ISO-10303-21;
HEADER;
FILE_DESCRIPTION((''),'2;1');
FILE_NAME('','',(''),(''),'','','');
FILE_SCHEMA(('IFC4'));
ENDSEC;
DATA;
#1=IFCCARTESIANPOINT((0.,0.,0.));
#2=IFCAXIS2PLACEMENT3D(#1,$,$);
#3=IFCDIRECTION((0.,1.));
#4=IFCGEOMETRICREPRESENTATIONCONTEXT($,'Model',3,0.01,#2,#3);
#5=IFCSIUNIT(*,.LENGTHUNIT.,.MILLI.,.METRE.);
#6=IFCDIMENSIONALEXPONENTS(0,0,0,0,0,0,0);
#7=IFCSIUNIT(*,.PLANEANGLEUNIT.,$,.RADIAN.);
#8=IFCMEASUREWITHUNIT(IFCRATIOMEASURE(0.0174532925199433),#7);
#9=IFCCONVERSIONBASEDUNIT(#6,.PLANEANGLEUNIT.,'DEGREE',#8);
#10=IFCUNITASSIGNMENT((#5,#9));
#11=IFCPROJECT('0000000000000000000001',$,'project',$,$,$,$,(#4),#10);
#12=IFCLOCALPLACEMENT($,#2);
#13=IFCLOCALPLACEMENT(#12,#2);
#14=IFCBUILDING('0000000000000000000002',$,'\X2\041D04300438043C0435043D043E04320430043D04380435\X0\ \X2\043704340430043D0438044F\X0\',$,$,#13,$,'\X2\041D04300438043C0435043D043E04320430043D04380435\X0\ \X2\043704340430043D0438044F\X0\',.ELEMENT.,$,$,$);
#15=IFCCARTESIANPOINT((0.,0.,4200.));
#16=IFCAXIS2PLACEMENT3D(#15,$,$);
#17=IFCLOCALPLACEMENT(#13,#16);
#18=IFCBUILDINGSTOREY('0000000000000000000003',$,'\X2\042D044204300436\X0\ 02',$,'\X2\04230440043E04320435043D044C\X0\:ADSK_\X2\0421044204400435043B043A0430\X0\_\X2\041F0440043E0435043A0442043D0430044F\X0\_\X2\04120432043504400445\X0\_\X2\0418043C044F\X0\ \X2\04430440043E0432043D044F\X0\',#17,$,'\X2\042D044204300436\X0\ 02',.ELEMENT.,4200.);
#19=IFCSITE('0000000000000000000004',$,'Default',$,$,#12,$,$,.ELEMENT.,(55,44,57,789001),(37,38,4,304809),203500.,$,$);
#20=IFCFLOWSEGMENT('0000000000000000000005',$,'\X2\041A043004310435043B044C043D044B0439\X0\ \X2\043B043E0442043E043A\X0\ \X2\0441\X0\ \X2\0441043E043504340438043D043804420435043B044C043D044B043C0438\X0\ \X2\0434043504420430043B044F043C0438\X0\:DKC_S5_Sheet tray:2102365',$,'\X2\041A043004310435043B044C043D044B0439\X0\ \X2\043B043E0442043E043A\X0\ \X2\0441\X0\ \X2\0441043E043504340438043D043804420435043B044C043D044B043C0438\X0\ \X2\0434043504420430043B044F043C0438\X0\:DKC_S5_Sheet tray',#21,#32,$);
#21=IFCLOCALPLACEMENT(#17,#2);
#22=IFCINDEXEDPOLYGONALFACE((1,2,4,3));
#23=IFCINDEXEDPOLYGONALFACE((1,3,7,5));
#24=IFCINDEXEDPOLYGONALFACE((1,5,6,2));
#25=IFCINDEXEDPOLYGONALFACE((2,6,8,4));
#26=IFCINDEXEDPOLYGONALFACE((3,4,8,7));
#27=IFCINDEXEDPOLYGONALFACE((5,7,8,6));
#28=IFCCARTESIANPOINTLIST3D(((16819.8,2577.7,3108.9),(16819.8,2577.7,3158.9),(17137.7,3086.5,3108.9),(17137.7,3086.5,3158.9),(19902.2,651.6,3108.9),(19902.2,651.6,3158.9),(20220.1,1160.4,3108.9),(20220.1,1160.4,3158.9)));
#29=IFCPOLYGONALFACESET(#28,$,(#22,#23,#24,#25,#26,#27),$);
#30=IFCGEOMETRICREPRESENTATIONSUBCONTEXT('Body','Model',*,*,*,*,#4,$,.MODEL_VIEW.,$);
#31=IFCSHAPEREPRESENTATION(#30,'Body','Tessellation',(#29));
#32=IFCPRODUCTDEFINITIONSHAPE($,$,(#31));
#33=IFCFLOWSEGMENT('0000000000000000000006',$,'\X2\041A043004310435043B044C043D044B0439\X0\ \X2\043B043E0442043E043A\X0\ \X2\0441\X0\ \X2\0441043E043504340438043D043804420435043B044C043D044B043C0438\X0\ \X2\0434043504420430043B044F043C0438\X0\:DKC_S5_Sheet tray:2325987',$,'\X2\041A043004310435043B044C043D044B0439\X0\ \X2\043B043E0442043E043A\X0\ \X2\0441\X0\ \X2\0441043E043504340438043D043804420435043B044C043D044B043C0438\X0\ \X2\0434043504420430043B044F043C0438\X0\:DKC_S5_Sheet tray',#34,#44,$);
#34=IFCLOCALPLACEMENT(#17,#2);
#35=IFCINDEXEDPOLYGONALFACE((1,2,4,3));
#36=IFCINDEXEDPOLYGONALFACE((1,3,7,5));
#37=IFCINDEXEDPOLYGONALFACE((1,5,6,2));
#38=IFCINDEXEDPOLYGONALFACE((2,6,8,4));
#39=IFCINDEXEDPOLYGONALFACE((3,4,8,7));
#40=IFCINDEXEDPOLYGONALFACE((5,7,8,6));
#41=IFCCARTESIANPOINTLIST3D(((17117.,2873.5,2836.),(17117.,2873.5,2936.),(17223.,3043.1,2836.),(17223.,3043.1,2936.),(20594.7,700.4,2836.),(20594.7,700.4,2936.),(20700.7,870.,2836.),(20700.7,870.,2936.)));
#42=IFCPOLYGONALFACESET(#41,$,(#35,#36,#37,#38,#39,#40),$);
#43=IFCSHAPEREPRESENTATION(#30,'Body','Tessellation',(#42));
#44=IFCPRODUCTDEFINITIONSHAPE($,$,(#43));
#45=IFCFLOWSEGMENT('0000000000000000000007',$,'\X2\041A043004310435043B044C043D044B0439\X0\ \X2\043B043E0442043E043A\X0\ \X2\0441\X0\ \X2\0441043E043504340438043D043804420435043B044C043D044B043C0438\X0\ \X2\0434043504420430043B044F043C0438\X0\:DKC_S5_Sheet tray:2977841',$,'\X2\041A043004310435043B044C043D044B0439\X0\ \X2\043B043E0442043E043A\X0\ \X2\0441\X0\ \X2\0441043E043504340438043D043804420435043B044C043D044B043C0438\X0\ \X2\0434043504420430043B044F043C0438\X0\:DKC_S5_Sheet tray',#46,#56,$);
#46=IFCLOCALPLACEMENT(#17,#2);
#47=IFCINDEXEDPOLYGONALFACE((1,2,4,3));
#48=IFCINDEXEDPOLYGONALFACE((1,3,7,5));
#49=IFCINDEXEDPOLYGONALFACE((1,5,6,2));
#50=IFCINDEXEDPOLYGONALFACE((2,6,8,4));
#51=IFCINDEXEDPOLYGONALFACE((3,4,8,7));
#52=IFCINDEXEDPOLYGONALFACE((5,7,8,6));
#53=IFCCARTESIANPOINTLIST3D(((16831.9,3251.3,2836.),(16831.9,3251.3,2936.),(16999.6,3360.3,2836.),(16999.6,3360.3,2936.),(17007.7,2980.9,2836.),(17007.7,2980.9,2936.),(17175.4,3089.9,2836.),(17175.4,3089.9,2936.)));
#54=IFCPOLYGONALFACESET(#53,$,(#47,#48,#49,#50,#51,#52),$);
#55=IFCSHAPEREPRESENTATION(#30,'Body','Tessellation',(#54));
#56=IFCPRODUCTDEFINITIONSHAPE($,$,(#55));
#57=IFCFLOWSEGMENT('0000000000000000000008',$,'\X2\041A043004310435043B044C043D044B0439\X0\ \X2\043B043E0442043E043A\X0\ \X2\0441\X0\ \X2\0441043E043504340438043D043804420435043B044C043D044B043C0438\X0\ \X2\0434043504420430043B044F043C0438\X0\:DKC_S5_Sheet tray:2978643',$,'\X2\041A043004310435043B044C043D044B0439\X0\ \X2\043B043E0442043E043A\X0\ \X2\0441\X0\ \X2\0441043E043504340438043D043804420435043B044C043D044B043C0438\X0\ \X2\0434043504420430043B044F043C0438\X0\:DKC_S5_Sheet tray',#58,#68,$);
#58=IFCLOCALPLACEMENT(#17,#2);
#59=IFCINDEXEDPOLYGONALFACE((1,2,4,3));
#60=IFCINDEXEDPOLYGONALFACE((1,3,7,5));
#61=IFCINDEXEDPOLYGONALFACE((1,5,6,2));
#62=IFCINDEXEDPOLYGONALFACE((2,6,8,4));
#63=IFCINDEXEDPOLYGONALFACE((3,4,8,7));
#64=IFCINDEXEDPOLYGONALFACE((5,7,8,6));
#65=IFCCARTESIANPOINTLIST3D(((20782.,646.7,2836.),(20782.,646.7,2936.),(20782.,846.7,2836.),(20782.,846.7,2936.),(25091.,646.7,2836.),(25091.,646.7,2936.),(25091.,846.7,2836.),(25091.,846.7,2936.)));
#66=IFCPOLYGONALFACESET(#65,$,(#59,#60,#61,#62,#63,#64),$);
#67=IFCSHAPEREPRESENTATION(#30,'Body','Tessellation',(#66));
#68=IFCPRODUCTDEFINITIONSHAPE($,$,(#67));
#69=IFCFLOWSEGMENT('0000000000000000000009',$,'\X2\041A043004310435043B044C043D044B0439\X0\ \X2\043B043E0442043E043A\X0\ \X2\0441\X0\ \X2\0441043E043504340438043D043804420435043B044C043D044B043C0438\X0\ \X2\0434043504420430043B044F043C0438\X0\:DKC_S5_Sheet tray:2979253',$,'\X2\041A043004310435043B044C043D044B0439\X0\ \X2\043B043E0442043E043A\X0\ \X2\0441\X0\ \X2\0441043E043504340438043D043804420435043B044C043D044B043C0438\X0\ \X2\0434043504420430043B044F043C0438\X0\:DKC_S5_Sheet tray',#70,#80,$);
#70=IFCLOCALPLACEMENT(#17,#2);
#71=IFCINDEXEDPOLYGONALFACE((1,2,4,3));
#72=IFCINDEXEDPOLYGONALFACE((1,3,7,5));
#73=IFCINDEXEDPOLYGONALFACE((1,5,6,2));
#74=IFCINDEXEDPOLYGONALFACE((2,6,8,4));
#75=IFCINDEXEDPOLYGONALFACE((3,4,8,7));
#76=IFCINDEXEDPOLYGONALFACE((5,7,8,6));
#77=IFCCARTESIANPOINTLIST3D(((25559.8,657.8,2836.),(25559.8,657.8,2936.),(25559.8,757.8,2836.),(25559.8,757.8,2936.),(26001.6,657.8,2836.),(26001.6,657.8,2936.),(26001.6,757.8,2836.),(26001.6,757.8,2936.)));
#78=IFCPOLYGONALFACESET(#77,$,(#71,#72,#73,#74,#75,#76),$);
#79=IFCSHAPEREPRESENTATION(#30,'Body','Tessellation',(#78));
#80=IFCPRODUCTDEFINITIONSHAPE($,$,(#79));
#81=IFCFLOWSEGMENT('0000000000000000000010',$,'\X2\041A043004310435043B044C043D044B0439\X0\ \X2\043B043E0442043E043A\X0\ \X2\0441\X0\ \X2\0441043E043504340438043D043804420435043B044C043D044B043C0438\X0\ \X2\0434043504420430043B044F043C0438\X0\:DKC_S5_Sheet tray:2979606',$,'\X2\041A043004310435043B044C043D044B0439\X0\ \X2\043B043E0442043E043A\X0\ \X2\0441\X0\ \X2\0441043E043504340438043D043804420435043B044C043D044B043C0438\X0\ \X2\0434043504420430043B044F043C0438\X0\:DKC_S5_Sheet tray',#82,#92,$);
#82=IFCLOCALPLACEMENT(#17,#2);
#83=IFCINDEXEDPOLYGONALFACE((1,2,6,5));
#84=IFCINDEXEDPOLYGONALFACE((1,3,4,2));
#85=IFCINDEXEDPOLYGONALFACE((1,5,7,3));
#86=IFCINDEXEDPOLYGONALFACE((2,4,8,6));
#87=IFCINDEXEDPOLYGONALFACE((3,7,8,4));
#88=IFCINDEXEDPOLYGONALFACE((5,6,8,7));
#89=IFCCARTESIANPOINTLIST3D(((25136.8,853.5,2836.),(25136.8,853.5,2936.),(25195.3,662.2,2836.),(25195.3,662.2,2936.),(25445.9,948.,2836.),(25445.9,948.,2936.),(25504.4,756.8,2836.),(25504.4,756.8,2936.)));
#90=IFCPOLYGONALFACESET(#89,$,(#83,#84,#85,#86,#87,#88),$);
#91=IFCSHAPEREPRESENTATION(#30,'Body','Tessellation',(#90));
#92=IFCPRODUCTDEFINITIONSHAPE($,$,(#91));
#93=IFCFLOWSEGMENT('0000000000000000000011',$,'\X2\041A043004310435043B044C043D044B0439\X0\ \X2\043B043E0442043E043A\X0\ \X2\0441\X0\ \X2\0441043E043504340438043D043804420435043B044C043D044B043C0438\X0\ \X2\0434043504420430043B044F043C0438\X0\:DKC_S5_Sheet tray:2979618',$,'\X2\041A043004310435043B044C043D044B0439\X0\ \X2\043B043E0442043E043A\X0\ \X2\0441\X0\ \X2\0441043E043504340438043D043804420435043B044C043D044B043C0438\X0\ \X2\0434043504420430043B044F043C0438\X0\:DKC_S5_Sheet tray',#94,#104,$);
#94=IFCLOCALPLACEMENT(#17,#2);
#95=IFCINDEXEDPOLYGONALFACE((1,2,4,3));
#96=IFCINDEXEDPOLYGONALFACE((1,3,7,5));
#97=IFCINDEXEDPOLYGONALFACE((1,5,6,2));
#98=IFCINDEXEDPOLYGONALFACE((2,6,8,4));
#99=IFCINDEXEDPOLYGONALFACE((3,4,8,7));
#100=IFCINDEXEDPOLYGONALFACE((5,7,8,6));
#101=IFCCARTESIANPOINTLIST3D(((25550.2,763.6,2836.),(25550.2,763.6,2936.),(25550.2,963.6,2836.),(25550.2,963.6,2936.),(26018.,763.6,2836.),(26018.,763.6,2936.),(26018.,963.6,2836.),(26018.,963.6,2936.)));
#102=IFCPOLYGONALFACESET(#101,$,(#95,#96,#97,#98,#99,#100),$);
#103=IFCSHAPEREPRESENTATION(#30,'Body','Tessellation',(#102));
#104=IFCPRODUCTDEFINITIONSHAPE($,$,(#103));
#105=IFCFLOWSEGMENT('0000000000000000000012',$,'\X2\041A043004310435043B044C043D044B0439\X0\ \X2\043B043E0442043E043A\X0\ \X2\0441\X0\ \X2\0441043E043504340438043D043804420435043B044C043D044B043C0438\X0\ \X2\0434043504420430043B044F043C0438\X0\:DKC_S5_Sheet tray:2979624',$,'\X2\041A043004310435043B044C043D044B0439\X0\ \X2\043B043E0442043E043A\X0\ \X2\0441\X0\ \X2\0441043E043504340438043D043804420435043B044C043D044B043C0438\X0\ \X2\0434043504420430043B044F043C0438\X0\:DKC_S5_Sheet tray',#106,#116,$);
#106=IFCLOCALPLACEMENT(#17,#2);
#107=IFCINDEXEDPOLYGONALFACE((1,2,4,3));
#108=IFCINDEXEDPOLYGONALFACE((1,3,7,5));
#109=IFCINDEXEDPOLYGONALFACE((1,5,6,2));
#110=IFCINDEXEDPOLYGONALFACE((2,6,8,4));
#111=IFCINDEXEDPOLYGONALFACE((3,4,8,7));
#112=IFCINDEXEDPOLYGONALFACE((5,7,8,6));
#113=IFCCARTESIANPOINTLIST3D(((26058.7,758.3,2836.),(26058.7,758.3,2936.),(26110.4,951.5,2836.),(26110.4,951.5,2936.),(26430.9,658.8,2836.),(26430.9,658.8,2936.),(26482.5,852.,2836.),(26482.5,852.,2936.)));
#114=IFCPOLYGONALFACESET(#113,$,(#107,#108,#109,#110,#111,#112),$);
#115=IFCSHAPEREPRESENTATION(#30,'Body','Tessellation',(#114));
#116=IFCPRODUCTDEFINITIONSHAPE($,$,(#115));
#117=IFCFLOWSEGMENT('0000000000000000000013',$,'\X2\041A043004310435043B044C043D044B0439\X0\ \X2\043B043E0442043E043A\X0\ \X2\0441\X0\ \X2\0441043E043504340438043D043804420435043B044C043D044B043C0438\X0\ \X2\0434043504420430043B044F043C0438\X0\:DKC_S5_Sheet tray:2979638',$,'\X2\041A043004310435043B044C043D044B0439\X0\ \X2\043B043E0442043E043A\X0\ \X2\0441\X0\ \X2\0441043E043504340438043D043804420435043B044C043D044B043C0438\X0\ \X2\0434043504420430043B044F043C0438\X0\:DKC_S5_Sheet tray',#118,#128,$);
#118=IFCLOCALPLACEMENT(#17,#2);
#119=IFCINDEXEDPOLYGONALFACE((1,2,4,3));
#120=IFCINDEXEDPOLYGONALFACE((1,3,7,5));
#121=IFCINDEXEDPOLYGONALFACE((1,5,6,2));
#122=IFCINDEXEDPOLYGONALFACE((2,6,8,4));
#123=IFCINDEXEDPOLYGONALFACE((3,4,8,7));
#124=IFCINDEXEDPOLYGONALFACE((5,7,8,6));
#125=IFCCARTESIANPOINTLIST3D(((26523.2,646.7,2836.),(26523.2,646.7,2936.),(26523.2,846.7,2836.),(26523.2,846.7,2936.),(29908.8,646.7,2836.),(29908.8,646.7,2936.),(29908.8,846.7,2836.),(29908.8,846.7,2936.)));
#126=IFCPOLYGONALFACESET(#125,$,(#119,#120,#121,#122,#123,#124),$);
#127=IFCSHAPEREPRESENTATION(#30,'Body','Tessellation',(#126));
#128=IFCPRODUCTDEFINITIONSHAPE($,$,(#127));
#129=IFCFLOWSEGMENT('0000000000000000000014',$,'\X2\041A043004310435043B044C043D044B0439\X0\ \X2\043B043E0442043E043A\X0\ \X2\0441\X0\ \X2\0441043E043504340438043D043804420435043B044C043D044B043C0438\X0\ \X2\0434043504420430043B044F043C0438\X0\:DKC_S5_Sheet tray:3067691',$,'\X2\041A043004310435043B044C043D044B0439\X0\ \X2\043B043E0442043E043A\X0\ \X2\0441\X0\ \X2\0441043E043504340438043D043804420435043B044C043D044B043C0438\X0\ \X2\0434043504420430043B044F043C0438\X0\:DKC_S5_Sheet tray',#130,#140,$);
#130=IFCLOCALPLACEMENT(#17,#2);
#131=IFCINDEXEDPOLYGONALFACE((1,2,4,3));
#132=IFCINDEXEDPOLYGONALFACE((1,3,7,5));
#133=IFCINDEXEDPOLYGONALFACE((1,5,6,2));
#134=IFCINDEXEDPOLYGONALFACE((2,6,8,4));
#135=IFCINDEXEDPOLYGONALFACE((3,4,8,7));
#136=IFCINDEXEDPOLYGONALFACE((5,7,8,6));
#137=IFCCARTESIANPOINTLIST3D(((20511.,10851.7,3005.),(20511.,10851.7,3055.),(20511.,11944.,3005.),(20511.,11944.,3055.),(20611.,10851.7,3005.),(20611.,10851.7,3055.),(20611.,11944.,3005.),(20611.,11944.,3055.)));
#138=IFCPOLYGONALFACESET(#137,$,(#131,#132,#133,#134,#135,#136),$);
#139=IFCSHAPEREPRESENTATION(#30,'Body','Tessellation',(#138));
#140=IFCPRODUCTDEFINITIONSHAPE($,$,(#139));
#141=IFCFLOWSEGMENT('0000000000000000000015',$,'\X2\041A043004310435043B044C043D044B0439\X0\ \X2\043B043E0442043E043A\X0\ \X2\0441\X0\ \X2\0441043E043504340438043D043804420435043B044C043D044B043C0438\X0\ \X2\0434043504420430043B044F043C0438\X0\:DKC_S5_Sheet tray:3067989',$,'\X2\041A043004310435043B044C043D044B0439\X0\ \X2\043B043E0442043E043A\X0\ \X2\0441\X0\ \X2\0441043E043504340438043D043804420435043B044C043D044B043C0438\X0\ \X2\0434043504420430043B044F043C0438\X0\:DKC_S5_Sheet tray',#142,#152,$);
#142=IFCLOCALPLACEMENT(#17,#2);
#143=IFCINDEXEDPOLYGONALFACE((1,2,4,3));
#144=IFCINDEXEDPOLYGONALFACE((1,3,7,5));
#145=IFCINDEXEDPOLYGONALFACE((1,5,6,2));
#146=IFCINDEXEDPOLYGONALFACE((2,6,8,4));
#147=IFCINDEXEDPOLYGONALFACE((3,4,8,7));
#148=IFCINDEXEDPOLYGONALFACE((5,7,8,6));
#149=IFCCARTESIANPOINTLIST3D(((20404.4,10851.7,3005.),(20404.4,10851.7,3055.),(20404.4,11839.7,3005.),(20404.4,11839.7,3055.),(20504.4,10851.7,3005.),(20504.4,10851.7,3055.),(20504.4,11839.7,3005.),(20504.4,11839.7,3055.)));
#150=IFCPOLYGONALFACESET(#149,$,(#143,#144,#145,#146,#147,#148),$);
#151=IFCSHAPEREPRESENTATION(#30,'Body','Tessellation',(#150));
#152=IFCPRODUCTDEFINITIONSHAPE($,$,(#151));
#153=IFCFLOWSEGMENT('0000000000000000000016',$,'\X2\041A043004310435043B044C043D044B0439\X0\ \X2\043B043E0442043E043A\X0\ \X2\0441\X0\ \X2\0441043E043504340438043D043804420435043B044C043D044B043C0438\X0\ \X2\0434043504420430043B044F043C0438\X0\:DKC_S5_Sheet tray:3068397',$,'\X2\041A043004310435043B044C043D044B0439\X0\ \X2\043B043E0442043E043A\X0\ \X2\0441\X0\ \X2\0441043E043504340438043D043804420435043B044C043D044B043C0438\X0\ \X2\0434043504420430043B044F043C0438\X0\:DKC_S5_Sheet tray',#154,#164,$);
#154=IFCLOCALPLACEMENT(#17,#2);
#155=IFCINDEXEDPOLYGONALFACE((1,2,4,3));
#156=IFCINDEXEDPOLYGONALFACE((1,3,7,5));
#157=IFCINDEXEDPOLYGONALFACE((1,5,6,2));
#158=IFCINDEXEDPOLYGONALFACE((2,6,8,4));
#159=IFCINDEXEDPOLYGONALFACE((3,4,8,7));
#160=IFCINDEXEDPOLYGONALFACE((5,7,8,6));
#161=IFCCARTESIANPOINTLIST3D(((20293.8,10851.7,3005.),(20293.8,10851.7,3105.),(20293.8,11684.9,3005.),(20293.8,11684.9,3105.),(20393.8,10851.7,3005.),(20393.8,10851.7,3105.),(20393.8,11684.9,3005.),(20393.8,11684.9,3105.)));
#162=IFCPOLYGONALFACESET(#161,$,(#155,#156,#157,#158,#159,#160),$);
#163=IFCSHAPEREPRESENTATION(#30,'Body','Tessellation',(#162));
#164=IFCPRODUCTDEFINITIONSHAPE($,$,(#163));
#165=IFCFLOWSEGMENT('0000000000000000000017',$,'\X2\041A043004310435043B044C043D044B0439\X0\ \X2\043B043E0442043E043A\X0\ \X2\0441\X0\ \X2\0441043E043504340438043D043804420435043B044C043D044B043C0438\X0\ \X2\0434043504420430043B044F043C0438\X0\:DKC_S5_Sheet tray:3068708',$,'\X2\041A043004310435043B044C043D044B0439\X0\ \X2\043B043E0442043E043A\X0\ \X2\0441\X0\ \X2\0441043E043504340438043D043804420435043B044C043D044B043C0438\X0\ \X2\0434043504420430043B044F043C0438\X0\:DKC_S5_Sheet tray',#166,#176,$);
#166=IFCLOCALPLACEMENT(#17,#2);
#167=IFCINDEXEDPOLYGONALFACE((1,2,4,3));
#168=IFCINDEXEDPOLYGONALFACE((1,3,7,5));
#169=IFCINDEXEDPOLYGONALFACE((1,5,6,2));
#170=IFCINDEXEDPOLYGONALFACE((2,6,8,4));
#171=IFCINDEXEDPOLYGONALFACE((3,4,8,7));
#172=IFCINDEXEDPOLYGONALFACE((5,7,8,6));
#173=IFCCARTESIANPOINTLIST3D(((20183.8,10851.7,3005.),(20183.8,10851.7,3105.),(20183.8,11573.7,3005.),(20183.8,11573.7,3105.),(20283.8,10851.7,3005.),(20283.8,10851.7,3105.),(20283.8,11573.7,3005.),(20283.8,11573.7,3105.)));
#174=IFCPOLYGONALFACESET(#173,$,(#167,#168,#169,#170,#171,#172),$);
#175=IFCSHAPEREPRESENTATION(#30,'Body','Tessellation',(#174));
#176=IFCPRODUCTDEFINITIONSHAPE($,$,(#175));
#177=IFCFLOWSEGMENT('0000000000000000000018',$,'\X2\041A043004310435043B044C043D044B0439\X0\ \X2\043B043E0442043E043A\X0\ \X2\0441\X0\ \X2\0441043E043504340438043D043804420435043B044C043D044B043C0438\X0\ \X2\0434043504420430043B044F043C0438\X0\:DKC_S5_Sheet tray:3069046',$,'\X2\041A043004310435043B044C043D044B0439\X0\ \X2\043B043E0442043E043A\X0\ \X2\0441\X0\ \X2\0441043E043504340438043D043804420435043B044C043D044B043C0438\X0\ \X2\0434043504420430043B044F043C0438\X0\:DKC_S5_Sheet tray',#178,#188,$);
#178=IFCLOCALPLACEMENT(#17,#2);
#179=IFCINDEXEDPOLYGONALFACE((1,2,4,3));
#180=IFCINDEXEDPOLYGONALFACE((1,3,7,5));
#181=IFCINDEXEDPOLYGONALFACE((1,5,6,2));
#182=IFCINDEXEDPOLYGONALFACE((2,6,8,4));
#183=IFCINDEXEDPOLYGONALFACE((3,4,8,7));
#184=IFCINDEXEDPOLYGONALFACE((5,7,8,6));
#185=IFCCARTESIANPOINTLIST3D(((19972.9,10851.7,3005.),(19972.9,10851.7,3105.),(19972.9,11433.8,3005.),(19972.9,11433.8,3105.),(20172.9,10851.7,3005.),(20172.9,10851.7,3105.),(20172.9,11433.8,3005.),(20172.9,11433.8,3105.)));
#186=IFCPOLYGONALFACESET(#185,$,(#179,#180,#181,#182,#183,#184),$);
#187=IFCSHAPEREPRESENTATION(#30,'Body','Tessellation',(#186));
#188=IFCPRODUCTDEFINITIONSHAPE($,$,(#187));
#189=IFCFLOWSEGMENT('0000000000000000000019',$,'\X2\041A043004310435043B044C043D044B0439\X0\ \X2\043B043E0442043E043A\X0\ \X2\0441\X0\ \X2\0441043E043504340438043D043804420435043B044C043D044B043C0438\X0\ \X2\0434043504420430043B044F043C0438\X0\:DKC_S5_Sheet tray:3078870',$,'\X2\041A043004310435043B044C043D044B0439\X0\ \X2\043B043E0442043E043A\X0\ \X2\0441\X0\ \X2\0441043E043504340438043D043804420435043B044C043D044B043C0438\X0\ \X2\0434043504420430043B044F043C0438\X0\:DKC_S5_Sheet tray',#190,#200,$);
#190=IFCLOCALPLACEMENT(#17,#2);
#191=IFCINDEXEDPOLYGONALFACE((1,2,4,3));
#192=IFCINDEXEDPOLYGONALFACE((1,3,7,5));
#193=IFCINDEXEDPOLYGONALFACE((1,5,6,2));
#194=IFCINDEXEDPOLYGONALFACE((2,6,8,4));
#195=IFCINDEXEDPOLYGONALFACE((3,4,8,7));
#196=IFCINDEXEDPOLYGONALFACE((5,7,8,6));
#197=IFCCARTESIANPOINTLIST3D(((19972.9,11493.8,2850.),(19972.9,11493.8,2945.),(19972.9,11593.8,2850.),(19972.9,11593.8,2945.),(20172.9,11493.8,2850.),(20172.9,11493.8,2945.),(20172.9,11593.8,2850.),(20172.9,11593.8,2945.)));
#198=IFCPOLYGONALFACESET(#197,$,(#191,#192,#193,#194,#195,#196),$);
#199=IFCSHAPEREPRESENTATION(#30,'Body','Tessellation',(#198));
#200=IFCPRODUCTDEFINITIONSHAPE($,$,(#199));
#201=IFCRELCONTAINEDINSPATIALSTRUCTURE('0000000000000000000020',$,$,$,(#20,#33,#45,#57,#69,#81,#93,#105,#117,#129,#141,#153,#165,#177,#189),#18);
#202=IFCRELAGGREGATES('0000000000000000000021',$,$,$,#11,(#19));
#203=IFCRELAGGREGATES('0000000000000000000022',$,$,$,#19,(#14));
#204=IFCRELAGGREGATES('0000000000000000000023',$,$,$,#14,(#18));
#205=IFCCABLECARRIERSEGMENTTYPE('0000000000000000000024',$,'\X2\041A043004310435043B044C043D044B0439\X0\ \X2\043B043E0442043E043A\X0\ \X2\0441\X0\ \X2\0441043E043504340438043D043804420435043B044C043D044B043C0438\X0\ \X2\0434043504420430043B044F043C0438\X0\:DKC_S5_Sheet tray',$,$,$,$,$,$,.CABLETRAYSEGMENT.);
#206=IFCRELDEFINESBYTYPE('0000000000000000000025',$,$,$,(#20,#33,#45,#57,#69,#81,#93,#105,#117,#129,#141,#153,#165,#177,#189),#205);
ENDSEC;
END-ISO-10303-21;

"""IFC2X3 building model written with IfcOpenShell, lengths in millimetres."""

from ifc_helpers import new_model, entity, si_unit, converted_unit, direction, frame, frame_2d, origin, origin_2d_with_axis, place, context, subcontext, project, spatial, rectangle, extrude, type_object, element, save


model = new_model("IFC2X3")

# Units and contexts
model_context = context("Model", 3, precision=0.01, world=origin(), true_north=direction((0.0, 1.0)))
body_context = subcontext(model_context, "Body", "Model", "MODEL_VIEW")
ifc_project = project(units=[si_unit("LENGTHUNIT", "METRE", prefix="MILLI"), converted_unit("PLANEANGLEUNIT", "DEGREE", entity("IfcRatioMeasure", 0.0174532925199433), si_unit("PLANEANGLEUNIT", "RADIAN"), dimensions=[0, 0, 0, 0, 0, 0, 0])], contexts=[model_context])

# Site, building, storey
site_placement = place(None, frame((0.0, 0.0, 0.0)))
site = spatial("IfcSite", under=ifc_project, at=site_placement, Name="Default", CompositionType="ELEMENT", RefLatitude=(55, 44, 57, 789001), RefLongitude=(37, 38, 4, 304809), RefElevation=203500.0)
building_placement = place(site_placement, origin())
building = spatial("IfcBuilding", under=site, at=building_placement, Name="Наименование здания", LongName="Наименование здания", CompositionType="ELEMENT")
storey_placement = place(building_placement, frame((0.0, 0.0, 4200.0)))
storey = spatial("IfcBuildingStorey", under=building, at=storey_placement, Name="Этаж 02", ObjectType="Уровень:ADSK_Стрелка_Проектная_Вверх_Имя уровня", LongName="Этаж 02", CompositionType="ELEMENT", Elevation=4200.0)

# Flow segments
cable_carrier_segment_type = type_object("IfcCableCarrierSegmentType", Name="Кабельный лоток с соединительными деталями:DKC_S5_Sheet tray", PredefinedType="CABLETRAYSEGMENT")
flow_segment_1_placement = place(storey_placement, frame((16819.8, 651.6, 3108.9)))
element("IfcFlowSegment", 1, at=flow_segment_1_placement, inside=storey, type_object=cable_carrier_segment_type, Name="Кабельный лоток с соединительными деталями:DKC_S5_Sheet tray:2102365", ObjectType="Кабельный лоток с соединительными деталями:DKC_S5_Sheet tray", context=body_context, shape_type="SweptSolid", body=[
    extrude(rectangle(XDim=3634.7, YDim=600.0, at=frame_2d((0.0, 0.0), x_axis=(1.0, 0.0))), frame((1700.2, 1217.5, 0.0), z_axis=(0.0, 0.0, 1.0), x_axis=(-0.848048, 0.529919, 0.0)), (0.0, 0.0, 1.0), 50.0),
])
flow_segment_2_placement = place(storey_placement, frame((17117.0, 700.4, 2836.0)))
element("IfcFlowSegment", 2, at=flow_segment_2_placement, inside=storey, type_object=cable_carrier_segment_type, Name="Кабельный лоток с соединительными деталями:DKC_S5_Sheet tray:2325987", ObjectType="Кабельный лоток с соединительными деталями:DKC_S5_Sheet tray", context=body_context, shape_type="SweptSolid", body=[
    extrude(rectangle(XDim=4100.8, YDim=200.0, at=frame_2d((0.0, 0.0), x_axis=(1.0, 0.0))), frame((1791.8, 1171.3, 0.0), z_axis=(0.0, 0.0, 1.0), x_axis=(-0.848048, 0.529919, 0.0)), (0.0, 0.0, 1.0), 100.0),
])
flow_segment_3_placement = place(storey_placement, frame((16831.9, 2980.9, 2836.0)))
element("IfcFlowSegment", 3, at=flow_segment_3_placement, inside=storey, type_object=cable_carrier_segment_type, Name="Кабельный лоток с соединительными деталями:DKC_S5_Sheet tray:2977841", ObjectType="Кабельный лоток с соединительными деталями:DKC_S5_Sheet tray", context=body_context, shape_type="SweptSolid", body=[
    extrude(rectangle(XDim=322.6, YDim=200.0, at=frame_2d((0.0, 0.0), x_axis=(1.0, 0.0))), frame((171.7, 189.7, 0.0), z_axis=(0.0, 0.0, 1.0), x_axis=(-0.54501, 0.838429, 0.0)), (0.0, 0.0, 1.0), 100.0),
])
flow_segment_4_placement = place(storey_placement, frame((20782.0, 646.7, 2836.0)))
element("IfcFlowSegment", 4, at=flow_segment_4_placement, inside=storey, type_object=cable_carrier_segment_type, Name="Кабельный лоток с соединительными деталями:DKC_S5_Sheet tray:2978643", ObjectType="Кабельный лоток с соединительными деталями:DKC_S5_Sheet tray", context=body_context, shape_type="SweptSolid", body=[
    extrude(rectangle(XDim=4309.0, YDim=200.0, at=frame_2d((0.0, 0.0), x_axis=(1.0, 0.0))), frame((2154.5, 100.0, 0.0)), (0.0, 0.0, 1.0), 100.0),
])
flow_segment_5_placement = place(storey_placement, frame((25559.8, 657.8, 2836.0)))
element("IfcFlowSegment", 5, at=flow_segment_5_placement, inside=storey, type_object=cable_carrier_segment_type, Name="Кабельный лоток с соединительными деталями:DKC_S5_Sheet tray:2979253", ObjectType="Кабельный лоток с соединительными деталями:DKC_S5_Sheet tray", context=body_context, shape_type="SweptSolid", body=[
    extrude(rectangle(XDim=441.8, YDim=100.0, at=frame_2d((0.0, 0.0), x_axis=(1.0, 0.0))), frame((220.9, 50.0, 0.0)), (0.0, 0.0, 1.0), 100.0),
])
flow_segment_6_placement = place(storey_placement, frame((25136.8, 662.2, 2836.0)))
element("IfcFlowSegment", 6, at=flow_segment_6_placement, inside=storey, type_object=cable_carrier_segment_type, Name="Кабельный лоток с соединительными деталями:DKC_S5_Sheet tray:2979606", ObjectType="Кабельный лоток с соединительными деталями:DKC_S5_Sheet tray", context=body_context, shape_type="SweptSolid", body=[
    extrude(rectangle(XDim=323.3, YDim=200.0, at=frame_2d((0.0, 0.0), x_axis=(1.0, 0.0))), frame((183.8, 142.9, 0.0), z_axis=(0.0, 0.0, 1.0), x_axis=(0.956305, 0.292372, 0.0)), (0.0, 0.0, 1.0), 100.0),
])
flow_segment_7_placement = place(storey_placement, frame((25550.2, 763.6, 2836.0)))
element("IfcFlowSegment", 7, at=flow_segment_7_placement, inside=storey, type_object=cable_carrier_segment_type, Name="Кабельный лоток с соединительными деталями:DKC_S5_Sheet tray:2979618", ObjectType="Кабельный лоток с соединительными деталями:DKC_S5_Sheet tray", context=body_context, shape_type="SweptSolid", body=[
    extrude(rectangle(XDim=467.8, YDim=200.0, at=frame_2d((0.0, 0.0), x_axis=(1.0, 0.0))), frame((233.9, 100.0, 0.0)), (0.0, 0.0, 1.0), 100.0),
])
flow_segment_8_placement = place(storey_placement, frame((26058.7, 658.8, 2836.0)))
element("IfcFlowSegment", 8, at=flow_segment_8_placement, inside=storey, type_object=cable_carrier_segment_type, Name="Кабельный лоток с соединительными деталями:DKC_S5_Sheet tray:2979624", ObjectType="Кабельный лоток с соединительными деталями:DKC_S5_Sheet tray", context=body_context, shape_type="SweptSolid", body=[
    extrude(rectangle(XDim=385.2, YDim=200.0, at=frame_2d((0.0, 0.0), x_axis=(1.0, 0.0))), frame((211.9, 146.3, 0.0), z_axis=(0.0, 0.0, 1.0), x_axis=(0.966084, -0.258228, 0.0)), (0.0, 0.0, 1.0), 100.0),
])
flow_segment_9_placement = place(storey_placement, frame((26523.2, 646.7, 2836.0)))
element("IfcFlowSegment", 9, at=flow_segment_9_placement, inside=storey, type_object=cable_carrier_segment_type, Name="Кабельный лоток с соединительными деталями:DKC_S5_Sheet tray:2979638", ObjectType="Кабельный лоток с соединительными деталями:DKC_S5_Sheet tray", context=body_context, shape_type="SweptSolid", body=[
    extrude(rectangle(XDim=3385.6, YDim=200.0, at=frame_2d((0.0, 0.0), x_axis=(1.0, 0.0))), frame((1692.8, 100.0, 0.0)), (0.0, 0.0, 1.0), 100.0),
])
flow_segment_10_placement = place(storey_placement, frame((20511.0, 10851.7, 3005.0)))
element("IfcFlowSegment", 10, at=flow_segment_10_placement, inside=storey, type_object=cable_carrier_segment_type, Name="Кабельный лоток с соединительными деталями:DKC_S5_Sheet tray:3067691", ObjectType="Кабельный лоток с соединительными деталями:DKC_S5_Sheet tray", context=body_context, shape_type="SweptSolid", body=[
    extrude(rectangle(XDim=1092.4, YDim=100.0, at=origin_2d_with_axis()), frame((50.0, 546.2, 0.0), z_axis=(0.0, 0.0, 1.0), x_axis=(0.0, -1.0, 0.0)), (0.0, 0.0, 1.0), 50.0),
])
flow_segment_11_placement = place(storey_placement, frame((20404.4, 10851.7, 3005.0)))
element("IfcFlowSegment", 11, at=flow_segment_11_placement, inside=storey, type_object=cable_carrier_segment_type, Name="Кабельный лоток с соединительными деталями:DKC_S5_Sheet tray:3067989", ObjectType="Кабельный лоток с соединительными деталями:DKC_S5_Sheet tray", context=body_context, shape_type="SweptSolid", body=[
    extrude(rectangle(XDim=988.0, YDim=100.0, at=frame_2d((0.0, 0.0), x_axis=(1.0, 0.0))), frame((50.0, 494.0, 0.0), z_axis=(0.0, 0.0, 1.0), x_axis=(0.0, -1.0, 0.0)), (0.0, 0.0, 1.0), 50.0),
])
flow_segment_12_placement = place(storey_placement, frame((20293.8, 10851.7, 3005.0)))
element("IfcFlowSegment", 12, at=flow_segment_12_placement, inside=storey, type_object=cable_carrier_segment_type, Name="Кабельный лоток с соединительными деталями:DKC_S5_Sheet tray:3068397", ObjectType="Кабельный лоток с соединительными деталями:DKC_S5_Sheet tray", context=body_context, shape_type="SweptSolid", body=[
    extrude(rectangle(XDim=833.3, YDim=100.0, at=frame_2d((0.0, 0.0), x_axis=(1.0, 0.0))), frame((50.0, 416.6, 0.0), z_axis=(0.0, 0.0, 1.0), x_axis=(0.0, -1.0, 0.0)), (0.0, 0.0, 1.0), 100.0),
])
flow_segment_13_placement = place(storey_placement, frame((20183.8, 10851.7, 3005.0)))
element("IfcFlowSegment", 13, at=flow_segment_13_placement, inside=storey, type_object=cable_carrier_segment_type, Name="Кабельный лоток с соединительными деталями:DKC_S5_Sheet tray:3068708", ObjectType="Кабельный лоток с соединительными деталями:DKC_S5_Sheet tray", context=body_context, shape_type="SweptSolid", body=[
    extrude(rectangle(XDim=722.1, YDim=100.0, at=frame_2d((0.0, 0.0), x_axis=(1.0, 0.0))), frame((50.0, 361.0, 0.0), z_axis=(0.0, 0.0, 1.0), x_axis=(0.0, -1.0, 0.0)), (0.0, 0.0, 1.0), 100.0),
])
flow_segment_14_placement = place(storey_placement, frame((19972.9, 10851.7, 3005.0)))
element("IfcFlowSegment", 14, at=flow_segment_14_placement, inside=storey, type_object=cable_carrier_segment_type, Name="Кабельный лоток с соединительными деталями:DKC_S5_Sheet tray:3069046", ObjectType="Кабельный лоток с соединительными деталями:DKC_S5_Sheet tray", context=body_context, shape_type="SweptSolid", body=[
    extrude(rectangle(XDim=582.1, YDim=200.0, at=frame_2d((0.0, 0.0), x_axis=(1.0, 0.0))), frame((100.0, 291.1, 0.0), z_axis=(0.0, 0.0, 1.0), x_axis=(0.0, -1.0, 0.0)), (0.0, 0.0, 1.0), 100.0),
])
flow_segment_15_placement = place(storey_placement, frame((19972.9, 11493.8, 2850.0)))
element("IfcFlowSegment", 15, at=flow_segment_15_placement, inside=storey, type_object=cable_carrier_segment_type, Name="Кабельный лоток с соединительными деталями:DKC_S5_Sheet tray:3078870", ObjectType="Кабельный лоток с соединительными деталями:DKC_S5_Sheet tray", context=body_context, shape_type="SweptSolid", body=[
    extrude(rectangle(XDim=200.0, YDim=100.0, at=origin_2d_with_axis()), frame((100.0, 50.0, 0.0), z_axis=(0.0, 0.0, 1.0), x_axis=(-1.0, 0.0, 0.0)), (0.0, 0.0, 1.0), 95.0),
])

save(model, "model.ifc")
